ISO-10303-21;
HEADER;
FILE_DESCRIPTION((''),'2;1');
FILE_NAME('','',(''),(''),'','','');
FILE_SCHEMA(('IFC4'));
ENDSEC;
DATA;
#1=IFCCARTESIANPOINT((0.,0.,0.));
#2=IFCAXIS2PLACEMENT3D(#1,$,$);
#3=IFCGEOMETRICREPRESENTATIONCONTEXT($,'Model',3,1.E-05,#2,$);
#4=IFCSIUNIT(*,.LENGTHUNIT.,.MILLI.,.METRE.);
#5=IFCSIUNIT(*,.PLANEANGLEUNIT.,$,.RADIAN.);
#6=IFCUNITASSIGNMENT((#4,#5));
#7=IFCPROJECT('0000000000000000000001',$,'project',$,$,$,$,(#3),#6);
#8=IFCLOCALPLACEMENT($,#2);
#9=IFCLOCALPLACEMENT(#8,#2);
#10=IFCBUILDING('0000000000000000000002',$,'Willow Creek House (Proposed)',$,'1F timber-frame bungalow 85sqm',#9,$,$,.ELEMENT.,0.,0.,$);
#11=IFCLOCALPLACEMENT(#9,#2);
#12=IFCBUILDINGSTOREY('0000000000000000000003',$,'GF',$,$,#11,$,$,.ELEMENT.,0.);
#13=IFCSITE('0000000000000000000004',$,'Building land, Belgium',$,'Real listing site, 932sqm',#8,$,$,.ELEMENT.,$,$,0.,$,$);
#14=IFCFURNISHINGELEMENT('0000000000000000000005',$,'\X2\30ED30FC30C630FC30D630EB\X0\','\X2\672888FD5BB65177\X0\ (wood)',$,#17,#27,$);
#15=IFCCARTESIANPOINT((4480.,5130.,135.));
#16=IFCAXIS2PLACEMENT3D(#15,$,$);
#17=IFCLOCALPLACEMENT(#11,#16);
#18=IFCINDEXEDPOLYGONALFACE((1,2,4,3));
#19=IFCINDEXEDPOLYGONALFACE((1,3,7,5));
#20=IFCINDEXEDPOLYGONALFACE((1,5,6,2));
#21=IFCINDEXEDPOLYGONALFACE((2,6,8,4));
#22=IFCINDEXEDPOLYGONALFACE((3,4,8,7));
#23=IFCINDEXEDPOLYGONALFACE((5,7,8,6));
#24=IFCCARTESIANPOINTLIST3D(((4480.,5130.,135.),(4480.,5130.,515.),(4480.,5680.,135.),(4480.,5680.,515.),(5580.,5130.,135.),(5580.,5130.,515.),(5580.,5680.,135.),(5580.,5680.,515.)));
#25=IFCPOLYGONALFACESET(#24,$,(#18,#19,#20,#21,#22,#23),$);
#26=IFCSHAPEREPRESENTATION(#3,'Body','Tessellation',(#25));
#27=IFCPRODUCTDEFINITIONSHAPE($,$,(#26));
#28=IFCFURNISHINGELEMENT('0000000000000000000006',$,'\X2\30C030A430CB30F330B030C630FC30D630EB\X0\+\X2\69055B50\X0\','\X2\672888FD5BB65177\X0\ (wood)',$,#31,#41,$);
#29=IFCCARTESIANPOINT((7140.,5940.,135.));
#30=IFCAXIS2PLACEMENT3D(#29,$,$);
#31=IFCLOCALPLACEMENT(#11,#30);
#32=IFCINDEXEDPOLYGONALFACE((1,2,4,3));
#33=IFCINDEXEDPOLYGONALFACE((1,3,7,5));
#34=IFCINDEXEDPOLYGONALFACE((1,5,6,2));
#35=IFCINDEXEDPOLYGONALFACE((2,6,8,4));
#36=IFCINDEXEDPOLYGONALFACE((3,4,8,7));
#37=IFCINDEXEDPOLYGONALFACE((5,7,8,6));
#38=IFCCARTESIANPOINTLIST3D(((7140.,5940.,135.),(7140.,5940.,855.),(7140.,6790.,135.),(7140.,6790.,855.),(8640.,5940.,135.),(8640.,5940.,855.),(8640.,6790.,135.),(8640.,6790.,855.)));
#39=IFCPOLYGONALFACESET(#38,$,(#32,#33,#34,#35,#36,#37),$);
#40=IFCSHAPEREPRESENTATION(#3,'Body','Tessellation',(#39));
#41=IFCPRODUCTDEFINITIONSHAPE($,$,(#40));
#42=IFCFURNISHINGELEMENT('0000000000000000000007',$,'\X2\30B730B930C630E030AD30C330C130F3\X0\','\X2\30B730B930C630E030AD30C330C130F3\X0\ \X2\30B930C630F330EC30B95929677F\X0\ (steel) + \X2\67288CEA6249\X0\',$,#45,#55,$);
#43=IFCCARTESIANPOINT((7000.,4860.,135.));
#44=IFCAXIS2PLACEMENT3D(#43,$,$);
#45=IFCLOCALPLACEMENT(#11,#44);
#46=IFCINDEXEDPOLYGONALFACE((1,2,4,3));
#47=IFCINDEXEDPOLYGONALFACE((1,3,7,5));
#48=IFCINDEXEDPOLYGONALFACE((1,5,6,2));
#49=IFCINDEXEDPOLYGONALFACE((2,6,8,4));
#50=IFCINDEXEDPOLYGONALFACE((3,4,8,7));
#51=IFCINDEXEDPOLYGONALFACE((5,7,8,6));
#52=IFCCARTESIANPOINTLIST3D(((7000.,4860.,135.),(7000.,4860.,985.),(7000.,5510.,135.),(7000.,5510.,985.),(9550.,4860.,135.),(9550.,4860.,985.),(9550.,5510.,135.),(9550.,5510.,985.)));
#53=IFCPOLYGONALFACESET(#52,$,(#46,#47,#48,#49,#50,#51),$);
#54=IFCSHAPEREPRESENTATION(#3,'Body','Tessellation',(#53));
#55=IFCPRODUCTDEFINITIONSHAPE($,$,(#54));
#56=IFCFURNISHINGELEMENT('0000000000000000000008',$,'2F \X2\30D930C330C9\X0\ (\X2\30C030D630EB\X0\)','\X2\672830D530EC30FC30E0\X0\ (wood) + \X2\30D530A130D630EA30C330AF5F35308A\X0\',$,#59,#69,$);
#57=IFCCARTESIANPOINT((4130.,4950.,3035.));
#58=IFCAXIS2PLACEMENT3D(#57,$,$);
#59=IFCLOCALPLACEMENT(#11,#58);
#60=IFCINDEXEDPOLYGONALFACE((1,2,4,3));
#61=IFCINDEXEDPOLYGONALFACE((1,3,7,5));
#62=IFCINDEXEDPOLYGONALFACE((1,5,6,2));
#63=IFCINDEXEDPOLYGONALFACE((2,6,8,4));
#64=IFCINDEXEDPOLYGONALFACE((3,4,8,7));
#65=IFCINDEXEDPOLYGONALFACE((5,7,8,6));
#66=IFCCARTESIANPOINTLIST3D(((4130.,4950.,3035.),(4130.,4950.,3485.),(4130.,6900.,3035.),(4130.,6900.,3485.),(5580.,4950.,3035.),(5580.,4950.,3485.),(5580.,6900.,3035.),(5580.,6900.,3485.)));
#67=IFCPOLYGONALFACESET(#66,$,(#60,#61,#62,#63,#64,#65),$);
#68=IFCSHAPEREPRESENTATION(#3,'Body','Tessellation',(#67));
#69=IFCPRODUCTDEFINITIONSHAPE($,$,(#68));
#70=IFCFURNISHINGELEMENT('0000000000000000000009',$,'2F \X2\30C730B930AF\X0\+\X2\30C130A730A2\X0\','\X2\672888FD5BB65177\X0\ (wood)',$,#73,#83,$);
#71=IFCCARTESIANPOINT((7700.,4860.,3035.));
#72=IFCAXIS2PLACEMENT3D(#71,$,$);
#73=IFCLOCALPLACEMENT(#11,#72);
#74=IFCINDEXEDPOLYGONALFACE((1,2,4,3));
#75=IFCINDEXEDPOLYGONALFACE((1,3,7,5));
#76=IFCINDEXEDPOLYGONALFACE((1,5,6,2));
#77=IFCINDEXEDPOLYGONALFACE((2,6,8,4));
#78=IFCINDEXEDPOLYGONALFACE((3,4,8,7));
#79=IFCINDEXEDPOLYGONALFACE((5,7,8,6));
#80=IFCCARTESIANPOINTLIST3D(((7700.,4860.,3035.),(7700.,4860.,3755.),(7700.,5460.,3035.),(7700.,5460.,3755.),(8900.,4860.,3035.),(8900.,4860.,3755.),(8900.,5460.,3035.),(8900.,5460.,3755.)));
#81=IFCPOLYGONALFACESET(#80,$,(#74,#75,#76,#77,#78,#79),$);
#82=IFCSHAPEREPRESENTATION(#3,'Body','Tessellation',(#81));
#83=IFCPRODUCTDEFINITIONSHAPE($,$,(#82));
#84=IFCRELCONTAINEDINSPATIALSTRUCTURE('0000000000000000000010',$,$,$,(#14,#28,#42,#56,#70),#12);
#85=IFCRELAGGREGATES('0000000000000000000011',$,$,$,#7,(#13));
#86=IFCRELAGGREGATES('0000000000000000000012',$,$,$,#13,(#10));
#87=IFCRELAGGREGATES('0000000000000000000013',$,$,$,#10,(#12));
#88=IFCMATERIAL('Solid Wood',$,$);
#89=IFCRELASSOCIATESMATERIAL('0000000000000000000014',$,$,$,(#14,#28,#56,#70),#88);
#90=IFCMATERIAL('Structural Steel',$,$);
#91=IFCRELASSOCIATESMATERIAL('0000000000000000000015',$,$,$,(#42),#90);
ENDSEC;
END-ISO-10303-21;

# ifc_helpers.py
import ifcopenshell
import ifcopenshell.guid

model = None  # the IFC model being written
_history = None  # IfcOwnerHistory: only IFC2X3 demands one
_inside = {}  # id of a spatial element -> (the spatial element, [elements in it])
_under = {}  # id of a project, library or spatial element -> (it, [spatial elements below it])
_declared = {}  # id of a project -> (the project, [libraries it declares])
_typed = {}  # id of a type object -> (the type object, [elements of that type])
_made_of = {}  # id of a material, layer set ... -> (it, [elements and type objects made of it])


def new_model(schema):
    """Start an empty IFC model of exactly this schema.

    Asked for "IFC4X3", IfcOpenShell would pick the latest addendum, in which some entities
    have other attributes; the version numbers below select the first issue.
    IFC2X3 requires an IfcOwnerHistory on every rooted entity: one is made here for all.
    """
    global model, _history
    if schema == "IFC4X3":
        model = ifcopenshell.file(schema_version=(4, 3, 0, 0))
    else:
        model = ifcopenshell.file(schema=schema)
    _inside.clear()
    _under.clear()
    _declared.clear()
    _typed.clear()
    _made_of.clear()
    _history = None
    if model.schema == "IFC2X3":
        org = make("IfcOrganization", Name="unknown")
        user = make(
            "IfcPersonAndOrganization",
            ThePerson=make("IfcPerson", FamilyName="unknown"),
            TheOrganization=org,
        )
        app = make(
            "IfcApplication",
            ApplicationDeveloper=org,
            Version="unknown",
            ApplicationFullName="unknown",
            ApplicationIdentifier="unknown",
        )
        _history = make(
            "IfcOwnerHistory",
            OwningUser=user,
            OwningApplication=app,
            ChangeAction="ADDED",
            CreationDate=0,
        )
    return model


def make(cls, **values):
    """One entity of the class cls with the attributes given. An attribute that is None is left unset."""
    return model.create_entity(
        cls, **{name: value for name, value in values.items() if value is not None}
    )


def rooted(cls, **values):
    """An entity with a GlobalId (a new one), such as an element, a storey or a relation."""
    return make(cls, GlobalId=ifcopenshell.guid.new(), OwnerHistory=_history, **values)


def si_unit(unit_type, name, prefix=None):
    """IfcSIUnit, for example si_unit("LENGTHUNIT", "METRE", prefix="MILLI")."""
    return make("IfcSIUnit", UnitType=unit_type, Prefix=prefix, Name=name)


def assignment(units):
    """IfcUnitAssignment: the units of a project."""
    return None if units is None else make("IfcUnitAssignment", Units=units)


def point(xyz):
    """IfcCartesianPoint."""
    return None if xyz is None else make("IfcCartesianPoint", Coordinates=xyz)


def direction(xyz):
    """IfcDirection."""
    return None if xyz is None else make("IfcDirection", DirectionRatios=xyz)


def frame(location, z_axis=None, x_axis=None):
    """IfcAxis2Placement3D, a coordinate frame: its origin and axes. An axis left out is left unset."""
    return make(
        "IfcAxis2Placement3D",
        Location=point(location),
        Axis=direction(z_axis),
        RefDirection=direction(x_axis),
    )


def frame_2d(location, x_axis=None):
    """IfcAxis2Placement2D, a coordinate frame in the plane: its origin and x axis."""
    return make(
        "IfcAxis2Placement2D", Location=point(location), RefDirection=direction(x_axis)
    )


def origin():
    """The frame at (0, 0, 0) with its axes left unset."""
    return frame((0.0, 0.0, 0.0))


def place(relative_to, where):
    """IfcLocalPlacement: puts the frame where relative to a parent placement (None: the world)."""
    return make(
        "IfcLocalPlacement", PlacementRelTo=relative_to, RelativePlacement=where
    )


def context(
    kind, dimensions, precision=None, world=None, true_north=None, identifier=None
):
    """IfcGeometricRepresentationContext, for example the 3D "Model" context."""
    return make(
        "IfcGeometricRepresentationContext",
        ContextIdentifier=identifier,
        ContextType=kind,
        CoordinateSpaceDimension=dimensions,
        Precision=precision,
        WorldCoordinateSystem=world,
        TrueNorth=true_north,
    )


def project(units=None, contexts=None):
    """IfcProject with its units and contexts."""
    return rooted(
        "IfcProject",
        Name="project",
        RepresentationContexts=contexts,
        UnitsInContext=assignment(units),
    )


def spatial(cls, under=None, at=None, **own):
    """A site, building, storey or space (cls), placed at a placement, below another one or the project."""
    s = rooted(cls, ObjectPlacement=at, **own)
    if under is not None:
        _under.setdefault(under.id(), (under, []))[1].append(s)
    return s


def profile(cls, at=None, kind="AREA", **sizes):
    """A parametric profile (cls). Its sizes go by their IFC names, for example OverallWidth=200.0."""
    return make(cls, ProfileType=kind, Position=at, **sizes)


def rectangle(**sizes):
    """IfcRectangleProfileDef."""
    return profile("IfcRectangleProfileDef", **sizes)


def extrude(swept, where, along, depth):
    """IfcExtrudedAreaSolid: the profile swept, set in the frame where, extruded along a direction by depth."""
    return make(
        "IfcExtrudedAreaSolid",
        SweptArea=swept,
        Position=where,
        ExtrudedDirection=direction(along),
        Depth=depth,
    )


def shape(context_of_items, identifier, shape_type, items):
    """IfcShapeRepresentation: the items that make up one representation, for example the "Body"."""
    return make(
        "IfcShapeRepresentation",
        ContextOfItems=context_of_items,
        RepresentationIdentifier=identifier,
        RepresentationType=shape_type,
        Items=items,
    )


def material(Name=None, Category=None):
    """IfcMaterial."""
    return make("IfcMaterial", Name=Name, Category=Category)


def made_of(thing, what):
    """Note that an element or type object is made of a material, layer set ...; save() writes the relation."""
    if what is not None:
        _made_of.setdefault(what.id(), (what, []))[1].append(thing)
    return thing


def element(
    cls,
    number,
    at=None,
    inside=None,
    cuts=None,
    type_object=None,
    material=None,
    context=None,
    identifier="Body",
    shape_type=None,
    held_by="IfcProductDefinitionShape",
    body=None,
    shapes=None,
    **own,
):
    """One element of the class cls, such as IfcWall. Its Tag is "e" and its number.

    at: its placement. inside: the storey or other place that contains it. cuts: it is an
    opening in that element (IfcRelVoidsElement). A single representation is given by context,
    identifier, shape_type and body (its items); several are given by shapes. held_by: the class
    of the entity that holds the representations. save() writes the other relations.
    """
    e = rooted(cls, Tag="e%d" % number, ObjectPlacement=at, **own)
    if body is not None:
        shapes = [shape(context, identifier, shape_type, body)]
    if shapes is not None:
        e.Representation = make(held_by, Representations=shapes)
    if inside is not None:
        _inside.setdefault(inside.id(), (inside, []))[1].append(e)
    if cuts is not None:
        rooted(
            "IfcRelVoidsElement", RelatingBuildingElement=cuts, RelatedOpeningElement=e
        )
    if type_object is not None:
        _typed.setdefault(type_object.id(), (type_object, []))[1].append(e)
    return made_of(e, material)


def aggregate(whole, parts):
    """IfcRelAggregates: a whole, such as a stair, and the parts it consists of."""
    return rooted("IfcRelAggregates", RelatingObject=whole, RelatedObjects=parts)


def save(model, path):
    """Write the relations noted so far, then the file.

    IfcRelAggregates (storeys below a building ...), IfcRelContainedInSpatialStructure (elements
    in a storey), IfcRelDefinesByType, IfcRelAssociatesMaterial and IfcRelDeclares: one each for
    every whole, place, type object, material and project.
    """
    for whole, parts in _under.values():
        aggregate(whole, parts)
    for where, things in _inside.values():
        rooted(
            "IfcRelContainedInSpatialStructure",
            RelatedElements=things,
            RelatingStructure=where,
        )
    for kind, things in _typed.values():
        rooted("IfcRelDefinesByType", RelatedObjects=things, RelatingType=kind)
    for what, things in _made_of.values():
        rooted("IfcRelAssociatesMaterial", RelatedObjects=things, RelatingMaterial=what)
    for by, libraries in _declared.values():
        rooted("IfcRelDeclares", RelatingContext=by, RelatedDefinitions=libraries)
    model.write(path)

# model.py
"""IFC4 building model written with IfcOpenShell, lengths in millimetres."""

from ifc_helpers import new_model, si_unit, frame, frame_2d, origin, place, context, project, spatial, rectangle, extrude, material, element, save


model = new_model("IFC4")

# Units and contexts
model_context = context("Model", 3, precision=1e-05, world=origin())
ifc_project = project(units=[si_unit("LENGTHUNIT", "METRE", prefix="MILLI"), si_unit("PLANEANGLEUNIT", "RADIAN")], contexts=[model_context])

# Site, building, storey
site_placement = place(None, origin())
site = spatial("IfcSite", under=ifc_project, at=site_placement, Name="Building land, Belgium", ObjectType="Real listing site, 932sqm", CompositionType="ELEMENT", RefElevation=0.0)
building_placement = place(site_placement, origin())
building = spatial("IfcBuilding", under=site, at=building_placement, Name="Willow Creek House (Proposed)", ObjectType="1F timber-frame bungalow 85sqm", CompositionType="ELEMENT", ElevationOfRefHeight=0.0, ElevationOfTerrain=0.0)
storey_placement = place(building_placement, origin())
storey = spatial("IfcBuildingStorey", under=building, at=storey_placement, Name="GF", CompositionType="ELEMENT", Elevation=0.0)

# Shared definitions
ifc_material_1 = material(Name="Solid Wood")

# Shared definitions
ifc_material_2 = material(Name="Structural Steel")

# Furnishing elements
furnishing_1_placement = place(storey_placement, frame((4480.0, 5130.0, 135.0)))
element("IfcFurnishingElement", 1, at=furnishing_1_placement, inside=storey, material=ifc_material_1, Name="ローテーブル", Description="木製家具 (wood)", context=model_context, shape_type="SweptSolid", body=[
    extrude(rectangle(XDim=1100.0, YDim=550.0, at=frame_2d((550.0, 275.0))), frame((4480.0, 5130.0, 135.0)), (0.0, 0.0, 1.0), 380.0),
])
furnishing_2_placement = place(storey_placement, frame((7140.0, 5940.0, 135.0)))
element("IfcFurnishingElement", 2, at=furnishing_2_placement, inside=storey, material=ifc_material_1, Name="ダイニングテーブル+椅子", Description="木製家具 (wood)", context=model_context, shape_type="SweptSolid", body=[
    extrude(rectangle(XDim=1500.0, YDim=850.0, at=frame_2d((750.0, 425.0))), frame((7140.0, 5940.0, 135.0)), (0.0, 0.0, 1.0), 720.0),
])
furnishing_3_placement = place(storey_placement, frame((7000.0, 4860.0, 135.0)))
element("IfcFurnishingElement", 3, at=furnishing_3_placement, inside=storey, material=ifc_material_2, Name="システムキッチン", Description="システムキッチン ステンレス天板 (steel) + 木質扉", context=model_context, shape_type="SweptSolid", body=[
    extrude(rectangle(XDim=2550.0, YDim=650.0, at=frame_2d((1275.0, 325.0))), frame((7000.0, 4860.0, 135.0)), (0.0, 0.0, 1.0), 850.0),
])
furnishing_4_placement = place(storey_placement, frame((4130.0, 4950.0, 3035.0)))
element("IfcFurnishingElement", 4, at=furnishing_4_placement, inside=storey, material=ifc_material_1, Name="2F ベッド (ダブル)", Description="木フレーム (wood) + ファブリック張り", context=model_context, shape_type="SweptSolid", body=[
    extrude(rectangle(XDim=1450.0, YDim=1950.0, at=frame_2d((725.0, 975.0))), frame((4130.0, 4950.0, 3035.0)), (0.0, 0.0, 1.0), 450.0),
])
furnishing_5_placement = place(storey_placement, frame((7700.0, 4860.0, 3035.0)))
element("IfcFurnishingElement", 5, at=furnishing_5_placement, inside=storey, material=ifc_material_1, Name="2F デスク+チェア", Description="木製家具 (wood)", context=model_context, shape_type="SweptSolid", body=[
    extrude(rectangle(XDim=1200.0, YDim=600.0, at=frame_2d((600.0, 300.0))), frame((7700.0, 4860.0, 3035.0)), (0.0, 0.0, 1.0), 720.0),
])

save(model, "model.ifc")
